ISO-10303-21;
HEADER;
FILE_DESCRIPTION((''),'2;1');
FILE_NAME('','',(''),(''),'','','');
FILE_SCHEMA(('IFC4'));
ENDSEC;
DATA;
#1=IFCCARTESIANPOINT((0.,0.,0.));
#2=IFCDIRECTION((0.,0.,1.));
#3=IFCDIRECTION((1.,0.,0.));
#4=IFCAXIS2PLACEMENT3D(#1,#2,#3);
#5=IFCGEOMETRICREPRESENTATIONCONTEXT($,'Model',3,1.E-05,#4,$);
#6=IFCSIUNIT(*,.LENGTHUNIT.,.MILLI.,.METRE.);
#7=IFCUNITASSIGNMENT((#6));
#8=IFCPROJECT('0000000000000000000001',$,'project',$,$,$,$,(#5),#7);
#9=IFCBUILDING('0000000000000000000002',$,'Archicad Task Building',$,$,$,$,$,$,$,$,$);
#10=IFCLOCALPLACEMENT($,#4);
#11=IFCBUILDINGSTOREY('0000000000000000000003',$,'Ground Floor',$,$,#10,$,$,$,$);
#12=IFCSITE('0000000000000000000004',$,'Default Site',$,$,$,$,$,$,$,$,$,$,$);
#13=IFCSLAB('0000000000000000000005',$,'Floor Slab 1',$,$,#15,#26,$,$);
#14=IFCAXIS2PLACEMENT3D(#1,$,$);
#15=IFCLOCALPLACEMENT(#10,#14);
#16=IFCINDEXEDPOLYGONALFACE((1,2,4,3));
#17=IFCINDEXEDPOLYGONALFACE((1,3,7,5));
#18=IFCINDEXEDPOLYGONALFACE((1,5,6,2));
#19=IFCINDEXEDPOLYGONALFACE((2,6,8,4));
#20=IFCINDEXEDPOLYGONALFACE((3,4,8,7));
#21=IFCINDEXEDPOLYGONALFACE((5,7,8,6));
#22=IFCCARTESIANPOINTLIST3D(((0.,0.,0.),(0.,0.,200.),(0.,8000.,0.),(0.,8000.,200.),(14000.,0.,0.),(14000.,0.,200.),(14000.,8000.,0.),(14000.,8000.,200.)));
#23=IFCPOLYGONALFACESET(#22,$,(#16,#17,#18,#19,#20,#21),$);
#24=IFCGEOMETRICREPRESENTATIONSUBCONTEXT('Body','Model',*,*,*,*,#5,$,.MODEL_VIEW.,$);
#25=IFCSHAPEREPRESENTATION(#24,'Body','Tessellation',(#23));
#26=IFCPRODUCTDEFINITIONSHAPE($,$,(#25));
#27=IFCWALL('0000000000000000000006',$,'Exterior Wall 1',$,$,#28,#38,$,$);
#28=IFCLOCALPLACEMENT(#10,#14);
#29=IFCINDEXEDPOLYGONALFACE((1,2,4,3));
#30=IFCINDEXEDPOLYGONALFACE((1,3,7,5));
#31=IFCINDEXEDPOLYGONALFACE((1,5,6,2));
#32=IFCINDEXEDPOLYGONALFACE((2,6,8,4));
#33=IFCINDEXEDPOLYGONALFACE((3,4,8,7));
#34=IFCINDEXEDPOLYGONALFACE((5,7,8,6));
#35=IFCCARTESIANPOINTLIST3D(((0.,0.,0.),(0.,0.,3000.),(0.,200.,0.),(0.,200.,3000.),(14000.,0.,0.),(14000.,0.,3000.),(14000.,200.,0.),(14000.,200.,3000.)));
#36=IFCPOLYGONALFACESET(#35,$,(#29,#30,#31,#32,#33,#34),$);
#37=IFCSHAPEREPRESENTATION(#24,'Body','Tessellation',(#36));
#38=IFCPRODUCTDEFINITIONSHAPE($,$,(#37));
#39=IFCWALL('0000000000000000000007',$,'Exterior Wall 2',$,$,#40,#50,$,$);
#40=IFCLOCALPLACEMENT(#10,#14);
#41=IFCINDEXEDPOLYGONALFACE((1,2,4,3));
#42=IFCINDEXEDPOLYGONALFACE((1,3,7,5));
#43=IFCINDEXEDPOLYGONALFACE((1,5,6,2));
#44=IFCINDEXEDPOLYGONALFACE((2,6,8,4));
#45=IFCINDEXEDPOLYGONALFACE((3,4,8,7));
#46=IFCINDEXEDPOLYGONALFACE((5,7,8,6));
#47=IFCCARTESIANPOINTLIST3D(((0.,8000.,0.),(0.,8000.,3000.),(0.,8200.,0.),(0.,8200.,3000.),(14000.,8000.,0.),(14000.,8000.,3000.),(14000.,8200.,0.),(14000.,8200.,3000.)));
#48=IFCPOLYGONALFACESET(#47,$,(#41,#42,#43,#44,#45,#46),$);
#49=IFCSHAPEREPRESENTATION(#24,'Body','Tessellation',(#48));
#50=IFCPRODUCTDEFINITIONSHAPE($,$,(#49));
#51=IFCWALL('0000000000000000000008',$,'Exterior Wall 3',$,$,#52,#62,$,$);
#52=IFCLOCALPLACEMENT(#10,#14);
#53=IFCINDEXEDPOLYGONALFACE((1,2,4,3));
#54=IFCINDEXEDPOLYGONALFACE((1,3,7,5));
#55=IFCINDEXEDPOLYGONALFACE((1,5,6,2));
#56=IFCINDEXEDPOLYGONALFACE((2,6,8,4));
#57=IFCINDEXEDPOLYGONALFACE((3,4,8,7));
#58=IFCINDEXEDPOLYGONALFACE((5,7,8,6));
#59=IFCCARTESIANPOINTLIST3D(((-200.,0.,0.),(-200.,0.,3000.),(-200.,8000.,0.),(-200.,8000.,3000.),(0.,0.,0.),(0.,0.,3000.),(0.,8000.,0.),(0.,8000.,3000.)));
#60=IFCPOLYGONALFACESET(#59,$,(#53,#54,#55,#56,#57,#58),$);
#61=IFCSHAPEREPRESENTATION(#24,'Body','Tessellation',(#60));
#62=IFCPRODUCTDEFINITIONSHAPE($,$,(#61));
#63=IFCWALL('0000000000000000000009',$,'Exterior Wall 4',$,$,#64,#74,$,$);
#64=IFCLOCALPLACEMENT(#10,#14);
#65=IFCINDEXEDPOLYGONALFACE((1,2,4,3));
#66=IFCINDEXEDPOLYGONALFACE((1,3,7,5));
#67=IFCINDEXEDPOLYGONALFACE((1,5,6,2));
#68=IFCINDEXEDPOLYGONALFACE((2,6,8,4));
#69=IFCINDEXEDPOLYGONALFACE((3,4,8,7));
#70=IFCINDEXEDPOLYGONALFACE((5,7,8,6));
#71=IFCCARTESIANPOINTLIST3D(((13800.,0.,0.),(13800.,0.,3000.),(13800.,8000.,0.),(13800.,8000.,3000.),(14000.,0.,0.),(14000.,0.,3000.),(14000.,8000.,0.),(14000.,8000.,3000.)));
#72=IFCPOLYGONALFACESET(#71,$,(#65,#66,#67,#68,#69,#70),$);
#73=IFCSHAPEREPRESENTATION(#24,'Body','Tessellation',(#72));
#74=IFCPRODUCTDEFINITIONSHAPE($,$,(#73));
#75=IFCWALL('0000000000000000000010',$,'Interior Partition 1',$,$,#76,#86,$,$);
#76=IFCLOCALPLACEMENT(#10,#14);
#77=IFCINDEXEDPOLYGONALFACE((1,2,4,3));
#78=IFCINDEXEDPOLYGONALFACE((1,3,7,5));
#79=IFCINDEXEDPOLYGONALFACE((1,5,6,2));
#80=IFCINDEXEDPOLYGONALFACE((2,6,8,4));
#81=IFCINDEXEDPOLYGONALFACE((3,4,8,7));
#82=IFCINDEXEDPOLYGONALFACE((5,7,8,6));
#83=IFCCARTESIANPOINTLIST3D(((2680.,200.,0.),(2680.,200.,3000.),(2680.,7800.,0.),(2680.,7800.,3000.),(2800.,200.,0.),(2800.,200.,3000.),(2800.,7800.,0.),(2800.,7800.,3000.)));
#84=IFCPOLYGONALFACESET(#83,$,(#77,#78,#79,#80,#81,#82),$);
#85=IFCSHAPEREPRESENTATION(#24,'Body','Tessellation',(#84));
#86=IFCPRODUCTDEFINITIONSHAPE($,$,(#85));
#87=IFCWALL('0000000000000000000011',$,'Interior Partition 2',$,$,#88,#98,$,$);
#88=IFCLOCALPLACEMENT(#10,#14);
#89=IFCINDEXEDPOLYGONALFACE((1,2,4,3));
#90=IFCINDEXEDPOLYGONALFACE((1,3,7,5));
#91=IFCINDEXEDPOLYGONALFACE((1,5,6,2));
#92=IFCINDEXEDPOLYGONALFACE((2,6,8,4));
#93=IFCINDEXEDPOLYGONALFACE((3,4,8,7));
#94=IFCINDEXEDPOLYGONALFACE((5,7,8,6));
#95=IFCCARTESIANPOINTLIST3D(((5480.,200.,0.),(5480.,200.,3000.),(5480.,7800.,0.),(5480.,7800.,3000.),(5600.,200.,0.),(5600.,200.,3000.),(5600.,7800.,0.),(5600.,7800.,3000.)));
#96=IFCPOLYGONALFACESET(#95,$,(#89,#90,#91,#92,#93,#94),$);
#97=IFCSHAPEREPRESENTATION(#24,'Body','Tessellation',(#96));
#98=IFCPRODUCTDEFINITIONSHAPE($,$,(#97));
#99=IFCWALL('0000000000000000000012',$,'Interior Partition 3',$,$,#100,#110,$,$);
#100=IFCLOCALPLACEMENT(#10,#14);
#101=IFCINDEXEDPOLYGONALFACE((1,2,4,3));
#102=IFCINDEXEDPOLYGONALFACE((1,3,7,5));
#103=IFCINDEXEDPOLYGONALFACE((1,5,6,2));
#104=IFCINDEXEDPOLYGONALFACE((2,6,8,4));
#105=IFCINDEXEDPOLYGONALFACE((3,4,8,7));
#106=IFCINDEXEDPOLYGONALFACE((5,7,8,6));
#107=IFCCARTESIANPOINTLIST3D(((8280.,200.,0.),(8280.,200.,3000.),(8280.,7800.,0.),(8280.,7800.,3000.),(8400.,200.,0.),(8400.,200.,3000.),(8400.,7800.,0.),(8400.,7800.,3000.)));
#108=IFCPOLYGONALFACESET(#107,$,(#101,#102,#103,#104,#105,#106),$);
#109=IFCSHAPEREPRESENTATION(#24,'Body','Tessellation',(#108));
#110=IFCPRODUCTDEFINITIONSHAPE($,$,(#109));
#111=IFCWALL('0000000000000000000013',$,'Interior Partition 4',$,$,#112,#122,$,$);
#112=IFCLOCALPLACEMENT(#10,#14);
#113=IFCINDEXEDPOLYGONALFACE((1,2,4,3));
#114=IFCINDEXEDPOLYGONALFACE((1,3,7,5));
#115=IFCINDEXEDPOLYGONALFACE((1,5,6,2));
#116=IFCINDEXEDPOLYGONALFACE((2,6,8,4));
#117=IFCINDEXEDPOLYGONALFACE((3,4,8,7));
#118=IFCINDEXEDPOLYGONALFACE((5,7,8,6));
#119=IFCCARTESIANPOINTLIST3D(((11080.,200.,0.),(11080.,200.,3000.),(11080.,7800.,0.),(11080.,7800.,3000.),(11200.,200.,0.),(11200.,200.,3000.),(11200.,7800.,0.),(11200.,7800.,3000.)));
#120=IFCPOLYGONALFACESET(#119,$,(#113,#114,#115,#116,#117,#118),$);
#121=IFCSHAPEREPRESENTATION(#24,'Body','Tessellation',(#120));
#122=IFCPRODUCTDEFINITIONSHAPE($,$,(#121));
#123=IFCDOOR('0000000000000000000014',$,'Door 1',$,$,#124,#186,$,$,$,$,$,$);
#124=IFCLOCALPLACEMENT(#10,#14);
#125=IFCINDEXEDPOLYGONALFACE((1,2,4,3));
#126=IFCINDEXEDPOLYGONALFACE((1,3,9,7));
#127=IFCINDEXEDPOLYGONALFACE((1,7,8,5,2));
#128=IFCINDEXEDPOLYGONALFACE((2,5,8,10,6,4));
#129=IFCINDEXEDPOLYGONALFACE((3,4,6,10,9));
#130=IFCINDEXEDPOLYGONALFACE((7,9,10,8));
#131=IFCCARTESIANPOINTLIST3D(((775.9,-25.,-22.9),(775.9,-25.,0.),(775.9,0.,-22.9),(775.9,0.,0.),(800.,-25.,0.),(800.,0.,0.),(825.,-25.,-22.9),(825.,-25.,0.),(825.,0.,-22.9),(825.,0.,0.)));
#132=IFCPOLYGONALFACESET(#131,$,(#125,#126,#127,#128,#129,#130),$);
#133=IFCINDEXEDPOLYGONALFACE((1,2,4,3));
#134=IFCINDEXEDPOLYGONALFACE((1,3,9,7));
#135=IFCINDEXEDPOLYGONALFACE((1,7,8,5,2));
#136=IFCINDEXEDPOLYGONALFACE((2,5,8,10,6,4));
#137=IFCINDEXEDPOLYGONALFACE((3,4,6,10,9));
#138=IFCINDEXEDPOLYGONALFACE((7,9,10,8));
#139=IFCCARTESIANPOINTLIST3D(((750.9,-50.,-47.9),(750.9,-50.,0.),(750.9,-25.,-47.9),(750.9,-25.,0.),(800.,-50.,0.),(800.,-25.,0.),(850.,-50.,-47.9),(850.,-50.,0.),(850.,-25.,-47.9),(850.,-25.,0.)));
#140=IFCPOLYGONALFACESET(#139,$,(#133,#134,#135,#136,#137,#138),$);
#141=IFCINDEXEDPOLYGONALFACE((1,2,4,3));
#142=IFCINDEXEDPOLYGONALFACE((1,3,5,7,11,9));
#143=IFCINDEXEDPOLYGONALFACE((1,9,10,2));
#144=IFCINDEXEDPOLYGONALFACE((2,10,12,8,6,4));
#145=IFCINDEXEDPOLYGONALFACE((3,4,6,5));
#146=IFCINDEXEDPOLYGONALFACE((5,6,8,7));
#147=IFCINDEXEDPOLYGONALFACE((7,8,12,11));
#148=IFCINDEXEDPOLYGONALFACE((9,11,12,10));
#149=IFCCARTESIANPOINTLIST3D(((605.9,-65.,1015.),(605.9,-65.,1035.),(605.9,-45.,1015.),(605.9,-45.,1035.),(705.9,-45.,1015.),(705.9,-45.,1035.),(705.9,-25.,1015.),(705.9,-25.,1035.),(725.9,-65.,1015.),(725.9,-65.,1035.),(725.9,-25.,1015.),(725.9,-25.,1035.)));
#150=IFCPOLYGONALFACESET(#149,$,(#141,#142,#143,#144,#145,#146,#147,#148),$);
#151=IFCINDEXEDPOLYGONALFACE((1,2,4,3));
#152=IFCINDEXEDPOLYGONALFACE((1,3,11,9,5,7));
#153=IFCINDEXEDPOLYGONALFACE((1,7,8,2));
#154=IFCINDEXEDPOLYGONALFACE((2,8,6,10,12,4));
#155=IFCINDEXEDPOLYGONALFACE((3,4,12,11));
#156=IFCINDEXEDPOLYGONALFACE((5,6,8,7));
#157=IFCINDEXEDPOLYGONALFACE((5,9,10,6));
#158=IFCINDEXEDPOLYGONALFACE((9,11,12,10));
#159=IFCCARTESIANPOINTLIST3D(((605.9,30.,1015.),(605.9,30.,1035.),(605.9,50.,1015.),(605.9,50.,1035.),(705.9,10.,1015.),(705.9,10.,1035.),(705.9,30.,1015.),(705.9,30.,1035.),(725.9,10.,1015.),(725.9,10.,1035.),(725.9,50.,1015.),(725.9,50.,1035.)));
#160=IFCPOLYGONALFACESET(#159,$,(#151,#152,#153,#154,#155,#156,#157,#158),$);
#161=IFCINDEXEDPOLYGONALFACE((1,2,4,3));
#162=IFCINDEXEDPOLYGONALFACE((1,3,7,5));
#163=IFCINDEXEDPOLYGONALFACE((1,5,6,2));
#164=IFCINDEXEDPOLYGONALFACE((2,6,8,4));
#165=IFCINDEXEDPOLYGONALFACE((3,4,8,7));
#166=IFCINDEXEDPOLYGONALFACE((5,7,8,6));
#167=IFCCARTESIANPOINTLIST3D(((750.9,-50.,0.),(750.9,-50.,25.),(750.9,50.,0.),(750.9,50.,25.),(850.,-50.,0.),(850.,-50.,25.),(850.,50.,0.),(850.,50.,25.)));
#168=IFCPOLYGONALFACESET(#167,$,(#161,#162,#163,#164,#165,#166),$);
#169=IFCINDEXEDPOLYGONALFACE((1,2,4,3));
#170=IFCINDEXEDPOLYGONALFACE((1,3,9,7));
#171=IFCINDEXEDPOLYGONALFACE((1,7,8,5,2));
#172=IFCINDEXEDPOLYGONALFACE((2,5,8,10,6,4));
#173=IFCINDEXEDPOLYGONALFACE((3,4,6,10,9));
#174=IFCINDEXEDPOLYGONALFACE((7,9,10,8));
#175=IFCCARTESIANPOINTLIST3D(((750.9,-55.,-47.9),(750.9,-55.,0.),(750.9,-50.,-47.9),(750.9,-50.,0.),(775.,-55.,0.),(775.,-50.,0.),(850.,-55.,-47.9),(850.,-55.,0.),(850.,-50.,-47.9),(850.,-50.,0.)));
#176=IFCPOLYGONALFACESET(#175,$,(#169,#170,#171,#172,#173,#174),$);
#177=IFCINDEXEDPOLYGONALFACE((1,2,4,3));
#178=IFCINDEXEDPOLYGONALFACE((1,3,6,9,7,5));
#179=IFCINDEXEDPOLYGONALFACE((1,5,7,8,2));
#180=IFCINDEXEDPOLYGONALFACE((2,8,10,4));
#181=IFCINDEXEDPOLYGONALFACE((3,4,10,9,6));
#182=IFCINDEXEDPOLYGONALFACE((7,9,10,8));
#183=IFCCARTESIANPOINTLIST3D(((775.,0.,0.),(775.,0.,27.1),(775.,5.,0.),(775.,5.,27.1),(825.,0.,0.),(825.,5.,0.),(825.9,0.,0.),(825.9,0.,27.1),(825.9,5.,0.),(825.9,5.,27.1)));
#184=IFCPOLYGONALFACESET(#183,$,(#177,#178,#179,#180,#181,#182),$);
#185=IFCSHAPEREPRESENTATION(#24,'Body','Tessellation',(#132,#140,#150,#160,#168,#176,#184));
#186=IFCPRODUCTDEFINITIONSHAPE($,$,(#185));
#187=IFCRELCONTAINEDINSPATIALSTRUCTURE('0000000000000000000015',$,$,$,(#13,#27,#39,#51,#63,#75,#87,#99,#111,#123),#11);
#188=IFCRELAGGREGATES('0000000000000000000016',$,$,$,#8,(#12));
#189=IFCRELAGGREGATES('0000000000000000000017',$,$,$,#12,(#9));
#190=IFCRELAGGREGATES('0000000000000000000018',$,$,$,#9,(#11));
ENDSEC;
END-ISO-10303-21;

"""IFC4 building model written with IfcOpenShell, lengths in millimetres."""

from ifc_helpers import new_model, si_unit, frame, origin_with_axes, place, context, subcontext, project, spatial, line, indexed_curve, outline, extrude, element, save


model = new_model("IFC4")

# Units and contexts
model_context = context("Model", 3, precision=1e-05, world=origin_with_axes())
body_context = subcontext(model_context, "Body", "Model", "MODEL_VIEW")
ifc_project = project(units=[si_unit("LENGTHUNIT", "METRE", prefix="MILLI")], contexts=[model_context])

# Site, building, storey
site = spatial("IfcSite", under=ifc_project, Name="Default Site")
building = spatial("IfcBuilding", under=site, Name="Archicad Task Building")
storey_placement = place(None, origin_with_axes())
storey = spatial("IfcBuildingStorey", under=building, at=storey_placement, Name="Ground Floor")

# Slab
slab_placement = place(storey_placement, origin_with_axes())
element("IfcSlab", 1, at=slab_placement, inside=storey, Name="Floor Slab 1", context=body_context, shape_type="SweptSolid", body=[
    extrude(outline(indexed_curve([(0.0, 0.0), (14000.0, 0.0), (14000.0, 8000.0), (0.0, 8000.0), (0.0, 0.0)])), None, (0.0, 0.0, 1.0), 200.0),
])

# Walls
for number, where, z_axis, x_axis, name in (
    (2, (0.0, 0.0, 0.0), (0.0, 0.0, 1.0), (1.0, 0.0, 0.0), "Exterior Wall 1"),
    (3, (0.0, 8000.0, 0.0), (0.0, 0.0, 1.0), (1.0, 0.0, 0.0), "Exterior Wall 2"),
):
    element("IfcWall", number, at=place(storey_placement, frame(where, z_axis=z_axis, x_axis=x_axis)), inside=storey, Name=name, context=body_context, shape_type="SweptSolid", body=[
        extrude(outline(indexed_curve([(0.0, 0.0), (0.0, 200.0), (14000.0, 200.0), (14000.0, 0.0), (0.0, 0.0)], self_intersect=False)), origin_with_axes(), (0.0, 0.0, 1.0), 3000.0),
    ])
for number, where, z_axis, x_axis, name in (
    (4, (0.0, 0.0, 0.0), (0.0, 0.0, 1.0), (0.0, 1.0, 0.0), "Exterior Wall 3"),
    (5, (14000.0, 0.0, 0.0), (0.0, 0.0, 1.0), (0.0, 1.0, 0.0), "Exterior Wall 4"),
):
    element("IfcWall", number, at=place(storey_placement, frame(where, z_axis=z_axis, x_axis=x_axis)), inside=storey, Name=name, context=body_context, shape_type="SweptSolid", body=[
        extrude(outline(indexed_curve([(0.0, 0.0), (0.0, 200.0), (8000.0, 200.0), (8000.0, 0.0), (0.0, 0.0)], self_intersect=False)), origin_with_axes(), (0.0, 0.0, 1.0), 3000.0),
    ])
for number, where, z_axis, x_axis, name in (
    (6, (2800.0, 200.0, 0.0), (0.0, 0.0, 1.0), (0.0, 1.0, 0.0), "Interior Partition 1"),
    (7, (5600.0, 200.0, 0.0), (0.0, 0.0, 1.0), (0.0, 1.0, 0.0), "Interior Partition 2"),
    (8, (8400.0, 200.0, 0.0), (0.0, 0.0, 1.0), (0.0, 1.0, 0.0), "Interior Partition 3"),
    (9, (11200.0, 200.0, 0.0), (0.0, 0.0, 1.0), (0.0, 1.0, 0.0), "Interior Partition 4"),
):
    element("IfcWall", number, at=place(storey_placement, frame(where, z_axis=z_axis, x_axis=x_axis)), inside=storey, Name=name, context=body_context, shape_type="SweptSolid", body=[
        extrude(outline(indexed_curve([(0.0, 0.0), (0.0, 120.0), (7600.0, 120.0), (7600.0, 0.0), (0.0, 0.0)], self_intersect=False)), origin_with_axes(), (0.0, 0.0, 1.0), 3000.0),
    ])

# Door
door_1_placement = place(storey_placement, frame((800.0, -50.0, 0.0), z_axis=(0.0, 0.0, 1.0), x_axis=(1.0, 0.0, 0.0)))
element("IfcDoor", 10, at=door_1_placement, inside=storey, Name="Door 1", context=body_context, shape_type="SweptSolid", body=[
    extrude(outline(indexed_curve([(0.0, 0.0), (0.0, 2.1), (0.9, 2.1), (0.9, 0.0), (-24.1, 0.0), (-24.1, -22.9), (25.0, -22.9), (25.0, 0.0)], segments=[line(1, 2, 3, 4, 5, 6, 7, 8, 1)])), frame((0.0, 25.0, 0.0), z_axis=(0.0, -1.0, 0.0), x_axis=(1.0, 0.0, 0.0)), (0.0, 0.0, -1.0), 25.0),
    extrude(outline(indexed_curve([(0.0, 0.0), (0.0, 2.1), (0.9, 2.1), (0.9, 0.0), (-49.1, 0.0), (-49.1, -47.9), (50.0, -47.9), (50.0, 0.0)], segments=[line(1, 2, 3, 4, 5, 6, 7, 8, 1)])), frame((0.0, 0.0, 0.0), z_axis=(0.0, -1.0, 0.0), x_axis=(1.0, 0.0, 0.0)), (0.0, 0.0, -1.0), 25.0),
    extrude(outline(indexed_curve([(0.0, 0.0), (-49.1, 0.0), (-49.1, 35.0), (0.0, 35.0)], segments=[line(1, 2, 3, 4, 1)])), frame((25.0, 25.0, 25.0), z_axis=(0.0, 0.0, 1.0), x_axis=(1.0, 0.0, 0.0)), (0.0, 0.0, 1.0), -47.9),
    extrude(outline(indexed_curve([(0.0, 0.0), (0.0, -40.0), (-120.0, -40.0), (-120.0, -20.0), (-20.0, -20.0), (-20.0, 0.0)], segments=[line(1, 2, 3, 4, 5, 6, 1)])), frame((-74.1, 25.0, 1015.0), z_axis=(0.0, 0.0, 1.0), x_axis=(1.0, 0.0, 0.0)), (0.0, 0.0, 1.0), 20.0),
    extrude(outline(indexed_curve([(0.0, 0.0), (0.0, 40.0), (-120.0, 40.0), (-120.0, 20.0), (-20.0, 20.0), (-20.0, 0.0)], segments=[line(1, 2, 3, 4, 5, 6, 1)])), frame((-74.1, 60.0, 1015.0), z_axis=(0.0, 0.0, 1.0), x_axis=(1.0, 0.0, 0.0)), (0.0, 0.0, 1.0), 20.0),
    extrude(outline(indexed_curve([(0.0, 0.0), (-99.1, 0.0), (-99.1, 100.0), (0.0, 100.0)], segments=[line(1, 2, 3, 4, 1)])), frame((50.0, 0.0, 0.0), z_axis=(0.0, 0.0, 1.0), x_axis=(1.0, 0.0, 0.0)), (0.0, 0.0, 1.0), 25.0),
    extrude(outline(indexed_curve([(0.0, 0.0), (0.0, 27.1), (50.9, 27.1), (50.9, 0.0), (-24.1, 0.0), (-24.1, -47.9), (75.0, -47.9), (75.0, 0.0)], segments=[line(1, 2, 3, 4, 5, 6, 7, 8, 1)])), frame((-25.0, -5.0, 0.0), z_axis=(0.0, -1.0, 0.0), x_axis=(1.0, 0.0, 0.0)), (0.0, 0.0, -1.0), 5.0),
    extrude(outline(indexed_curve([(0.0, 0.0), (0.0, 27.1), (50.9, 27.1), (50.9, 0.0), (0.9, 0.0), (0.9, -22.9), (50.0, -22.9), (50.0, 0.0)], segments=[line(1, 2, 3, 4, 5, 6, 7, 8, 1)])), frame((-25.0, 50.0, 0.0), z_axis=(0.0, -1.0, 0.0), x_axis=(1.0, 0.0, 0.0)), (0.0, 0.0, -1.0), 5.0),
])

save(model, "model.ifc")
